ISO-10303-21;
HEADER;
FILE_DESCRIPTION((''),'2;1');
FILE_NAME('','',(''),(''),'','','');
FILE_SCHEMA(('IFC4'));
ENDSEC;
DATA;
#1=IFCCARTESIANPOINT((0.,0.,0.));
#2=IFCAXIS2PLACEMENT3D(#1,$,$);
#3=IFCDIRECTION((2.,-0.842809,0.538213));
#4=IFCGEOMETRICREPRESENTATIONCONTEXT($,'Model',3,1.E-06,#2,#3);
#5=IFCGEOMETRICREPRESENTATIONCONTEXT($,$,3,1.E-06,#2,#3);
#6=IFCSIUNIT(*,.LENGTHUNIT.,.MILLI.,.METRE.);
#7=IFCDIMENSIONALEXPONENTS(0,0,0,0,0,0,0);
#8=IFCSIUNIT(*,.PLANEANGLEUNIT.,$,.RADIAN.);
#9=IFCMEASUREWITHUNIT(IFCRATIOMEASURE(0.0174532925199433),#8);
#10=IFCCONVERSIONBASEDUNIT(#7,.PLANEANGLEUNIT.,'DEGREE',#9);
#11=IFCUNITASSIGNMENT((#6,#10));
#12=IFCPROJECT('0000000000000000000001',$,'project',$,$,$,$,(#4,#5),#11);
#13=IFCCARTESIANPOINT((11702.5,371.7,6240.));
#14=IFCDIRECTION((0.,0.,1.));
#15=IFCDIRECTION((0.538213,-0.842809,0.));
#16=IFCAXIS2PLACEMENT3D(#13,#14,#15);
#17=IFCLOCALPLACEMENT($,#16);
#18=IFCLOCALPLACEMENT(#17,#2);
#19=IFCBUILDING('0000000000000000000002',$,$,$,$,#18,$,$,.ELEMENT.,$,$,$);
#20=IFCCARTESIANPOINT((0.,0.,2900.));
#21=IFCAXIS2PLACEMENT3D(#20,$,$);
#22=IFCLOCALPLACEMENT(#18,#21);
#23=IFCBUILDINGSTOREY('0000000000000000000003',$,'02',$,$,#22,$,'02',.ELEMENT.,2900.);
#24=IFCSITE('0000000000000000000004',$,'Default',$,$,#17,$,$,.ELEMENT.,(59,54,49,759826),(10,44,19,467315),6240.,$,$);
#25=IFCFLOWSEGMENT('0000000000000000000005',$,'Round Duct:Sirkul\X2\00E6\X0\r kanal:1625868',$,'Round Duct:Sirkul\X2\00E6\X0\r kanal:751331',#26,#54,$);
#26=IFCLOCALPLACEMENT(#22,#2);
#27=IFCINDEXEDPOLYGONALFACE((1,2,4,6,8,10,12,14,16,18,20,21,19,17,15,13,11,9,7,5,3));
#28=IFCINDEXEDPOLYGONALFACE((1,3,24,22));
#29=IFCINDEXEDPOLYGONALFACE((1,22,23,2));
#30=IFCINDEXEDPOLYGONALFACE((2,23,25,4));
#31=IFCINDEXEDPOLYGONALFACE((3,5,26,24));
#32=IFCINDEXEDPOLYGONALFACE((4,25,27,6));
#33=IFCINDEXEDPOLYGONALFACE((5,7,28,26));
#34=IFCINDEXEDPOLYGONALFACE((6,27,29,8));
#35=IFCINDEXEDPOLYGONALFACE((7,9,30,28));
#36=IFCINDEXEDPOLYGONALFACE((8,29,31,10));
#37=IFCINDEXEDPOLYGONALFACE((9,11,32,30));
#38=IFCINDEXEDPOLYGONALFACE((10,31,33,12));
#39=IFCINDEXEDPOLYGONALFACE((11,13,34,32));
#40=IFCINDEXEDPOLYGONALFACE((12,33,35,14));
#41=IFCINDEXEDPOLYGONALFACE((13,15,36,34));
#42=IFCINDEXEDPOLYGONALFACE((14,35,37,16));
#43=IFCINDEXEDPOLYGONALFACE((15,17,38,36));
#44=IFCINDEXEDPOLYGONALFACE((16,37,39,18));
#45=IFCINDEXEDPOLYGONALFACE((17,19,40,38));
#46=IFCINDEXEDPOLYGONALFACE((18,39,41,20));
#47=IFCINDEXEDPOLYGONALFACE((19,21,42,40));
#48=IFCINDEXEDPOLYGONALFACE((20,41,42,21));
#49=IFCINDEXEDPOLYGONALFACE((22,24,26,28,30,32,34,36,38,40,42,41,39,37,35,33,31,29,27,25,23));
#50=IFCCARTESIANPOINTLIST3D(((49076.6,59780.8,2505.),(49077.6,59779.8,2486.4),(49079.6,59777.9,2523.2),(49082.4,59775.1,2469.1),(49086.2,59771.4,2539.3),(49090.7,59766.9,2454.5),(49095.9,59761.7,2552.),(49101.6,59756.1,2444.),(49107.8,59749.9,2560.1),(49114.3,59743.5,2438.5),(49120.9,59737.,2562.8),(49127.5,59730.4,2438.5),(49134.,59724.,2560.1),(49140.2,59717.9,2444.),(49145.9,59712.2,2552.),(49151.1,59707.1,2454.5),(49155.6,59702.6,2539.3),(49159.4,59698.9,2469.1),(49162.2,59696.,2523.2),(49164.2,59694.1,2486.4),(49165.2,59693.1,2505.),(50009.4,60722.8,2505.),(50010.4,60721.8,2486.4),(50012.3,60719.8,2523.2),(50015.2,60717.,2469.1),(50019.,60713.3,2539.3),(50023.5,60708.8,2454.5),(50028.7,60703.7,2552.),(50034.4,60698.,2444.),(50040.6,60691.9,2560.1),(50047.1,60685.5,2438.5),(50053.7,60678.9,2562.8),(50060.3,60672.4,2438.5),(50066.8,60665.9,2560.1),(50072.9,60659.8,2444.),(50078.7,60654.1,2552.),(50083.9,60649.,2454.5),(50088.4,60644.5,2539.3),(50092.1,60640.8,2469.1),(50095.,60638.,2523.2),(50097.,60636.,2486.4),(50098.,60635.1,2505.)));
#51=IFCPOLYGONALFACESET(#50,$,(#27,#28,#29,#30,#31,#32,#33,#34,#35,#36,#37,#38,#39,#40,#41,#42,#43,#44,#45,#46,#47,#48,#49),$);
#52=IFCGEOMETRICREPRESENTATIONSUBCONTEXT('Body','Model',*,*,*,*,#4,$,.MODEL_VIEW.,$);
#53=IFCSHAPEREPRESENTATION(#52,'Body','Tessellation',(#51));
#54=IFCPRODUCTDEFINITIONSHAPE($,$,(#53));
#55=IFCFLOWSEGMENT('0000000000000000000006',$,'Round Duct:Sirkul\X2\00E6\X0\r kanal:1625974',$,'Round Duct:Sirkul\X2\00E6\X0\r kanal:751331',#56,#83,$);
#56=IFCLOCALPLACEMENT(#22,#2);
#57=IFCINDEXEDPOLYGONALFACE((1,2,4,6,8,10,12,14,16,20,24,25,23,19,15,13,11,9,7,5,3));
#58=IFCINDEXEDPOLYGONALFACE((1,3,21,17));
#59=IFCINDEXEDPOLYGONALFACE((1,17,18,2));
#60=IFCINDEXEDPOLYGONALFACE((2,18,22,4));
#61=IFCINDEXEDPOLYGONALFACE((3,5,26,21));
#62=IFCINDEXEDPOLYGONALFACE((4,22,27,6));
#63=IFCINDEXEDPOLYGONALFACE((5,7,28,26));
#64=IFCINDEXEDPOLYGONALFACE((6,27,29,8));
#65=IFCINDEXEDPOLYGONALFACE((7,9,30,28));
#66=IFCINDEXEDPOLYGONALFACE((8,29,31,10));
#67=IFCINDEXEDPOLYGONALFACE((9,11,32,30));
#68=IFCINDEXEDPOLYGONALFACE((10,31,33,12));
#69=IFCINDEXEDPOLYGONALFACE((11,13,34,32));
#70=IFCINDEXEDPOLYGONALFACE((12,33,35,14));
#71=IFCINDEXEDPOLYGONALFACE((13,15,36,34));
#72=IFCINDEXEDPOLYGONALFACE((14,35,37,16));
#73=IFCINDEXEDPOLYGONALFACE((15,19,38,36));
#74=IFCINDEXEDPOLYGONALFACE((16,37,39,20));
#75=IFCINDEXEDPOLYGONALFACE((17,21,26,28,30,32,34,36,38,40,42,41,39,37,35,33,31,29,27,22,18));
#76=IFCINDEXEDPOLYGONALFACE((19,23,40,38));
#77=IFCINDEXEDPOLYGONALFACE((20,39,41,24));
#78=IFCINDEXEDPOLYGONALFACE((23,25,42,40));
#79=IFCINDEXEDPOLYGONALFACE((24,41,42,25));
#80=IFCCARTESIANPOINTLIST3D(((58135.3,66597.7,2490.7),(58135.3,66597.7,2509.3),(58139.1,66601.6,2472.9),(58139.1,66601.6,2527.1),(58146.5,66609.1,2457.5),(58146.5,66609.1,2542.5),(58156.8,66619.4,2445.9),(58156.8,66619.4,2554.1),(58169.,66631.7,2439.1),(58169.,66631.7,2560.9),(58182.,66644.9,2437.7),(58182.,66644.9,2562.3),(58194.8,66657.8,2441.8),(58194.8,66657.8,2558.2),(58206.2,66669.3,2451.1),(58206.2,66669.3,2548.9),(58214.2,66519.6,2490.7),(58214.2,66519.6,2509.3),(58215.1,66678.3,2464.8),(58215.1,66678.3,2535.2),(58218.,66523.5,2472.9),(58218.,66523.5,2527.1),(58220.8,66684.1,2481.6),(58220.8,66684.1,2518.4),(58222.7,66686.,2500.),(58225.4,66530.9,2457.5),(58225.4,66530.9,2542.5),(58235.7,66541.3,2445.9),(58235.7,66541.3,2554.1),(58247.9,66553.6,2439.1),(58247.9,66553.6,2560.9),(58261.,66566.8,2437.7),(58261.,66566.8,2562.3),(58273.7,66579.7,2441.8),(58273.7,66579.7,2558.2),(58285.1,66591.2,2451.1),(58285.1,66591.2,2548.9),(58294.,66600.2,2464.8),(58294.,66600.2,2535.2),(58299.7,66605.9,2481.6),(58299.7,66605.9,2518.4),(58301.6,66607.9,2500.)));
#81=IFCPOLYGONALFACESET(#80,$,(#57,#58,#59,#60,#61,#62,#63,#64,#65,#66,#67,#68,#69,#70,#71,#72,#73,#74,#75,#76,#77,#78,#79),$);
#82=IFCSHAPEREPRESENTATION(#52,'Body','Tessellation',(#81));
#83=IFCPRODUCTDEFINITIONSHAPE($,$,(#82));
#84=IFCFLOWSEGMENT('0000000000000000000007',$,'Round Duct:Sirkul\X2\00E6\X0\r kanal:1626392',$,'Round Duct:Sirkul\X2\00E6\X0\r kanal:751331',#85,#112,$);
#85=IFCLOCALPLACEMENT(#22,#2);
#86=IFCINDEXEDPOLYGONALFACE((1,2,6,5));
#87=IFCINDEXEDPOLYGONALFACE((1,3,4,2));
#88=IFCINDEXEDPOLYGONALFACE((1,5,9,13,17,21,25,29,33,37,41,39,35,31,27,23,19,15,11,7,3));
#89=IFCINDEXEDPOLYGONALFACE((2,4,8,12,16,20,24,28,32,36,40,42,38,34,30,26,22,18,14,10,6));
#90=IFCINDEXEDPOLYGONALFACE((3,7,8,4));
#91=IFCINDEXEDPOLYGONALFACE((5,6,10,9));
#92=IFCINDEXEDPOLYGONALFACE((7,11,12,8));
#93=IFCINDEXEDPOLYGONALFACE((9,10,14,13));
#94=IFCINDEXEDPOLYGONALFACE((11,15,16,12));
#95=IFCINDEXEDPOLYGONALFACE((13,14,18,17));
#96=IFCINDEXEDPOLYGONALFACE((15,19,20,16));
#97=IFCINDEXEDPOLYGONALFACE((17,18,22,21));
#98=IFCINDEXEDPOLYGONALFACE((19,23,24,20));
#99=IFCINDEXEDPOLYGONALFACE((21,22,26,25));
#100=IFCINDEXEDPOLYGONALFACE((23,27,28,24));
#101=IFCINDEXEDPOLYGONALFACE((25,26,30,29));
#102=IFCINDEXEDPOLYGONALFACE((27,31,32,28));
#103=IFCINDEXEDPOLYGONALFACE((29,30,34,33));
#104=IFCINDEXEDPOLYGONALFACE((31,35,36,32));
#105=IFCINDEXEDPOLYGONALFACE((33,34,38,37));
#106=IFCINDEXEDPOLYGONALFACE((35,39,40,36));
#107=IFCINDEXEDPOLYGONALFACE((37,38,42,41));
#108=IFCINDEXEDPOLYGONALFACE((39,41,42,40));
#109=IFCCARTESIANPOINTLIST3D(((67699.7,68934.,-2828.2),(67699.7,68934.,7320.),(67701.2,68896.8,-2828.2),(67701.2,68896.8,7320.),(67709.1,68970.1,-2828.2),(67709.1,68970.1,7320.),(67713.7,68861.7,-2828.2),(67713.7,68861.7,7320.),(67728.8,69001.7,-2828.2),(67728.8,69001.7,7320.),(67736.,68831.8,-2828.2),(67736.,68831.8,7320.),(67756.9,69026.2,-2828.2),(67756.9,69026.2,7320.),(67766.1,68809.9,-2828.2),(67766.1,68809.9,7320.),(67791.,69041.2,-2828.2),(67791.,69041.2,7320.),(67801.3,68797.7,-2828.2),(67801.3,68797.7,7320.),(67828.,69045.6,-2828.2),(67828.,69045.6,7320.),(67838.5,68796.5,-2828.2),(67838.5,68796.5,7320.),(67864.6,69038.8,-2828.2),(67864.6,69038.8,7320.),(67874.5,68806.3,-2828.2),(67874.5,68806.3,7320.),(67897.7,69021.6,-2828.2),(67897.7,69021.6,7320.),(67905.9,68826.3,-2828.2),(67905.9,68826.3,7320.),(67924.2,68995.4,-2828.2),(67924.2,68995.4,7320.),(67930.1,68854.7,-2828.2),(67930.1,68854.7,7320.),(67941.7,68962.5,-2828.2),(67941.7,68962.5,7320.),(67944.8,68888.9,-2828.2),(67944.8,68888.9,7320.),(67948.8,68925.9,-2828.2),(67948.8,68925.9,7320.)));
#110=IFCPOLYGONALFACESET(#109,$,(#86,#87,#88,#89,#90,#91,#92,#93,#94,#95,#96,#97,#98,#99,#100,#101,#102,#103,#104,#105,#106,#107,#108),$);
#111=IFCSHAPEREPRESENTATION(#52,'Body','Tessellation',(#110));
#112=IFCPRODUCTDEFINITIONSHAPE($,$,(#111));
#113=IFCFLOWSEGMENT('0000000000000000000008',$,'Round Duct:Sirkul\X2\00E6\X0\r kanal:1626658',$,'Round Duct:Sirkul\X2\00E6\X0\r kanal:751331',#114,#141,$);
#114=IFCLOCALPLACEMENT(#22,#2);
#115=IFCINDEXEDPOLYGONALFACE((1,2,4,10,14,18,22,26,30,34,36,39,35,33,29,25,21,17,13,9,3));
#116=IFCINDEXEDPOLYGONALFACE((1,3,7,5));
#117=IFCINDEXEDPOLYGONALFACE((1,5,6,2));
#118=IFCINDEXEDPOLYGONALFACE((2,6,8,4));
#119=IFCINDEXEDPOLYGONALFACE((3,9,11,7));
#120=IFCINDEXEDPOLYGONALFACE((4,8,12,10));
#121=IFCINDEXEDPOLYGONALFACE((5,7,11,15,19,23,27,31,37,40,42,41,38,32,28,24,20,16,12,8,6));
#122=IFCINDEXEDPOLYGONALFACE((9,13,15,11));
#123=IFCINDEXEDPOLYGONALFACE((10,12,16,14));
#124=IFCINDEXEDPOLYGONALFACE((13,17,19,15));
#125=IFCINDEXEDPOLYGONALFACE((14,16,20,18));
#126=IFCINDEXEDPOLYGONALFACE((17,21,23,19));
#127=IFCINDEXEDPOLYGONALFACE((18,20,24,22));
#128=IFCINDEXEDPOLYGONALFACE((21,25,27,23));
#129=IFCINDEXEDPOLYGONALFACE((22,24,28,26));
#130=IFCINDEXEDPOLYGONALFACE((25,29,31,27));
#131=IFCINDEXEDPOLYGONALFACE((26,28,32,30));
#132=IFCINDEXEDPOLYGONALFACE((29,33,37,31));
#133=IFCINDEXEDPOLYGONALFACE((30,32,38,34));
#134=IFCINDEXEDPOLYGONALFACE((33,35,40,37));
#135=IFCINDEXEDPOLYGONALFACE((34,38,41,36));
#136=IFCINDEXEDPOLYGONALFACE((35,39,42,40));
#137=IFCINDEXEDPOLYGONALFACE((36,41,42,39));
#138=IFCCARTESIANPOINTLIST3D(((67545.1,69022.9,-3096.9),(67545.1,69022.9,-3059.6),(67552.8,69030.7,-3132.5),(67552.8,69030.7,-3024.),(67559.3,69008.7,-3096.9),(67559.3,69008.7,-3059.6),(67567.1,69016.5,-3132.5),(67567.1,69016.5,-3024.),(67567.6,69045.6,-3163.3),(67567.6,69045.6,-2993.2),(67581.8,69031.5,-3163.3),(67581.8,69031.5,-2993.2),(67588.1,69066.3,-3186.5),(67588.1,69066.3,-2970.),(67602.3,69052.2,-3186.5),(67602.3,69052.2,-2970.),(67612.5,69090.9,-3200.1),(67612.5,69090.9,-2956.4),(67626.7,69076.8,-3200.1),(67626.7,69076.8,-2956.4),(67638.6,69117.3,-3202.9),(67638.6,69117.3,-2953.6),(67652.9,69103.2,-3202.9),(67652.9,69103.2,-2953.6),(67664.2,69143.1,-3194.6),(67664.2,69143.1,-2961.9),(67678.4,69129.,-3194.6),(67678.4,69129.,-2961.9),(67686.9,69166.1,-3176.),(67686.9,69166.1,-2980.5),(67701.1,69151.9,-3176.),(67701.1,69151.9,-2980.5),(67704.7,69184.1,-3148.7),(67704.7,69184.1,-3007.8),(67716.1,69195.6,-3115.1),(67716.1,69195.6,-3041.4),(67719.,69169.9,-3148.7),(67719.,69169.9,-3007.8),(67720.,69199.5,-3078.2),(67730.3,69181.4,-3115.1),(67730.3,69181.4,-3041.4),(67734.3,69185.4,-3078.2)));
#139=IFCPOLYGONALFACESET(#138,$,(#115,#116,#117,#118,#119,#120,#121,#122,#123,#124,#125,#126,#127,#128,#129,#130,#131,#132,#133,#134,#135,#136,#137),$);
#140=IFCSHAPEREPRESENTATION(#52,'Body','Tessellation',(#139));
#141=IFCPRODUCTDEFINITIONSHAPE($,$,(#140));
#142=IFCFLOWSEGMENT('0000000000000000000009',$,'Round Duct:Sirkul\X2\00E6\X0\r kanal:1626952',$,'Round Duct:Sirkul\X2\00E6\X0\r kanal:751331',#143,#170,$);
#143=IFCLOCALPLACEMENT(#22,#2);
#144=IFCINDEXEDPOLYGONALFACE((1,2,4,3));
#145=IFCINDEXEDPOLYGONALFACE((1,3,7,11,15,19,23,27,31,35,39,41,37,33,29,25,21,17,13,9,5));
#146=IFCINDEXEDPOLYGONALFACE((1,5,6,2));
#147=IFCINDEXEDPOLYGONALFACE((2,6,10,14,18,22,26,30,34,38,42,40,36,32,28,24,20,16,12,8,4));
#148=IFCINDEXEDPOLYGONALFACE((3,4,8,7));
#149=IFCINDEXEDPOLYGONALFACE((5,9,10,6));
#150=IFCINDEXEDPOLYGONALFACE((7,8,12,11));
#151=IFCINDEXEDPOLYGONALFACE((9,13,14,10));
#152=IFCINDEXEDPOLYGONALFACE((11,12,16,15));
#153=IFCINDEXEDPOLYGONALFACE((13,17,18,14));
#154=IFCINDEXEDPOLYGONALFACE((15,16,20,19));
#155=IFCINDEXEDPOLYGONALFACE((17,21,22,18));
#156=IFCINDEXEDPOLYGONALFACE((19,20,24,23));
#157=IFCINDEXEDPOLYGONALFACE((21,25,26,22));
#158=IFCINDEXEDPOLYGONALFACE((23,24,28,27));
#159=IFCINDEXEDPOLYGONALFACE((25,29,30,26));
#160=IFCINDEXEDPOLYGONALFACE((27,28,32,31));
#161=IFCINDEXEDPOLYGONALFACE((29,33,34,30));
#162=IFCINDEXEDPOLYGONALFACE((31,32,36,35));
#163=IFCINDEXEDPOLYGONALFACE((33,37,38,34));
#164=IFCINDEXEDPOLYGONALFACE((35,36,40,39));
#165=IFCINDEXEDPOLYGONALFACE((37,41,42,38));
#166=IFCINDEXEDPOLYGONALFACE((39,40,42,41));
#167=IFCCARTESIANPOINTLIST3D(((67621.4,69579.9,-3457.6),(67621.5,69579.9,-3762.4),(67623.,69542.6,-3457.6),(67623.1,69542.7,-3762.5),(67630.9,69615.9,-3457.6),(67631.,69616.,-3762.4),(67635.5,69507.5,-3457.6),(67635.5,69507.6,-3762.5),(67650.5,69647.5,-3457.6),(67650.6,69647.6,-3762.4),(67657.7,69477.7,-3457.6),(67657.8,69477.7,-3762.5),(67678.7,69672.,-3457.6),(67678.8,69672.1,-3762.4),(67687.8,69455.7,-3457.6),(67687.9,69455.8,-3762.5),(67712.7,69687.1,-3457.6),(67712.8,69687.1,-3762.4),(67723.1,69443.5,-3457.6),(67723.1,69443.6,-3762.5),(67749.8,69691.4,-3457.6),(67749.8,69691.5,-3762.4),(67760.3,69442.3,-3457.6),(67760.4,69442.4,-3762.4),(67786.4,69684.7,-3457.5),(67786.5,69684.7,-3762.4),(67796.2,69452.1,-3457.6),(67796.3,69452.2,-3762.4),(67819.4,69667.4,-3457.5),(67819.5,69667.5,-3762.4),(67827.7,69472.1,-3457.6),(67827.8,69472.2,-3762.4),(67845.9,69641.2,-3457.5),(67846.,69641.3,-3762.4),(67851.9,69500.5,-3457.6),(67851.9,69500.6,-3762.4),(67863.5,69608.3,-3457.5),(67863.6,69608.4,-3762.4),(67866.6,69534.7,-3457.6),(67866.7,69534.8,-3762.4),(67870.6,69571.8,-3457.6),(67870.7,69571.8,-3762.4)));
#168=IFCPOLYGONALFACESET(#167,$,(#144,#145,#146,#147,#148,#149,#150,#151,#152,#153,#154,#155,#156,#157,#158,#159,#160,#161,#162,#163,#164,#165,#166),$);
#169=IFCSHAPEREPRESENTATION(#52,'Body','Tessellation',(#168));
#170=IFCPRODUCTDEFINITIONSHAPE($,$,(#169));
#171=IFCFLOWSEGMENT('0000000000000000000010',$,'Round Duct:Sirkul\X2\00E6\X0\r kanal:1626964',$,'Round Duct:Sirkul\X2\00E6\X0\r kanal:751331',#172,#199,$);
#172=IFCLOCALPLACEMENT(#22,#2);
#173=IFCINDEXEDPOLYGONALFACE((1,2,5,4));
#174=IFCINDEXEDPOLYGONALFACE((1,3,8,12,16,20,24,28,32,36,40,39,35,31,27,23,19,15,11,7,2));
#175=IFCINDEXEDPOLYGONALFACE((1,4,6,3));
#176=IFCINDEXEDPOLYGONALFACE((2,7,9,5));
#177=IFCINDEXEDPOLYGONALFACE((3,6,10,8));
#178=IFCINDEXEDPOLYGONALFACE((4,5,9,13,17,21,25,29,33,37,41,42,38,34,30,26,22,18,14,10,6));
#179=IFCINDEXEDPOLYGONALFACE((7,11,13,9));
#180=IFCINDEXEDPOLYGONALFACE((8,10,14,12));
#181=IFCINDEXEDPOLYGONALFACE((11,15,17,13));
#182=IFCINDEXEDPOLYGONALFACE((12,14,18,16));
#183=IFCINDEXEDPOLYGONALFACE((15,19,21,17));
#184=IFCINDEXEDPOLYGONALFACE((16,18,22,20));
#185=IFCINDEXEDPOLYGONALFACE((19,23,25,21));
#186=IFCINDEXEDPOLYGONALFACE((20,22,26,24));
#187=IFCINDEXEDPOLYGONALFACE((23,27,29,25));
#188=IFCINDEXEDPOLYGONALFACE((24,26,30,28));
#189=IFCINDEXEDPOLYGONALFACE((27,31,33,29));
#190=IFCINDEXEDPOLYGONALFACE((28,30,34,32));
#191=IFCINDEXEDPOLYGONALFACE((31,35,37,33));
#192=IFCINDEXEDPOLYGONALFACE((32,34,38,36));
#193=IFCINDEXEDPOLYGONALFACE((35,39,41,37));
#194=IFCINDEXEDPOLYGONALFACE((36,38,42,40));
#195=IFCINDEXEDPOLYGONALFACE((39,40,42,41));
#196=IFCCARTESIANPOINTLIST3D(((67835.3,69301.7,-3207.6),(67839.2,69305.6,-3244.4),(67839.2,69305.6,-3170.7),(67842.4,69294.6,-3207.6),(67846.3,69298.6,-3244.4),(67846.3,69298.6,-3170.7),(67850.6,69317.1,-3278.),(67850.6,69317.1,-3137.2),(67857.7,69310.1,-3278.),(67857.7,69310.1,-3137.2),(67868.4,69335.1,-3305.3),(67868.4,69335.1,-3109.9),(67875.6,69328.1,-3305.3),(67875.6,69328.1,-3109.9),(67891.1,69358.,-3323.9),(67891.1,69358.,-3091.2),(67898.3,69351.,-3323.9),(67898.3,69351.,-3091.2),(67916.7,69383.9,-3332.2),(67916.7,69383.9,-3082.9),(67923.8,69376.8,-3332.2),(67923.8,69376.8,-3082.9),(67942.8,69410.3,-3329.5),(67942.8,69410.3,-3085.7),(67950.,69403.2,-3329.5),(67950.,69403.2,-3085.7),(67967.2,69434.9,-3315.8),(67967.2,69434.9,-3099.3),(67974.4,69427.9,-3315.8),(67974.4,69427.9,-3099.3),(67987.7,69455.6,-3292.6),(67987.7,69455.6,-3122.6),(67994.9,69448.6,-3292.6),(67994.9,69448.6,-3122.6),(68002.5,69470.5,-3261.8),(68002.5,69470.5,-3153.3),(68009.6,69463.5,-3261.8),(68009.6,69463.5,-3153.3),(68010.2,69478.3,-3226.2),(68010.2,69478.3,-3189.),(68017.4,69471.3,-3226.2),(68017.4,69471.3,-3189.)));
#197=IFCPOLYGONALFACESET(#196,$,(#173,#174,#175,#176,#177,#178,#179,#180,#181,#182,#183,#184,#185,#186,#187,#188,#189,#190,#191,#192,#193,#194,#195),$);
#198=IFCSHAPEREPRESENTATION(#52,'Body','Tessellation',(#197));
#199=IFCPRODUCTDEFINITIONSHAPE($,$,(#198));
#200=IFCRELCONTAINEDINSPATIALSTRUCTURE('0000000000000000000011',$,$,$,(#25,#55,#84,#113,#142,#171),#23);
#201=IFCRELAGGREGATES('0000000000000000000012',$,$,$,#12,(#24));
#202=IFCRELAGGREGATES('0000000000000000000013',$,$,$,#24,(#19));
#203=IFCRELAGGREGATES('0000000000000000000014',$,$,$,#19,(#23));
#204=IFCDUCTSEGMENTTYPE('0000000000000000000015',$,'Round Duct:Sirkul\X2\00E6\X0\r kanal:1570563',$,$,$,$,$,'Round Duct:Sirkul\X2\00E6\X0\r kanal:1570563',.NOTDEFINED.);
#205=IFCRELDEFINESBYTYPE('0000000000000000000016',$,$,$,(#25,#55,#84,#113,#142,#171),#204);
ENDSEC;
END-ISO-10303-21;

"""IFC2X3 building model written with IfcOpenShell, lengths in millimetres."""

from ifc_helpers import new_model, entity, si_unit, converted_unit, direction, frame, frame_2d, origin, origin_2d_with_axis, place, context, subcontext, project, spatial, circle, extrude, type_object, element, save


model = new_model("IFC2X3")

# Units and contexts
model_context = context("Model", 3, precision=1e-06, world=origin(), true_north=direction((2.0, -0.842809, 0.538213)))
context_of_model = context(None, 3, precision=1e-06, world=origin(), true_north=direction((2.0, -0.842809, 0.538213)))
body_context = subcontext(model_context, "Body", "Model", "MODEL_VIEW")
ifc_project = project(units=[si_unit("LENGTHUNIT", "METRE", prefix="MILLI"), converted_unit("PLANEANGLEUNIT", "DEGREE", entity("IfcRatioMeasure", 0.0174532925199433), si_unit("PLANEANGLEUNIT", "RADIAN"), dimensions=[0, 0, 0, 0, 0, 0, 0])], contexts=[model_context, context_of_model])

# Site, building, storey
site_placement = place(None, frame((11702.5, 371.7, 6240.0), z_axis=(0.0, 0.0, 1.0), x_axis=(0.538213, -0.842809, 0.0)))
site = spatial("IfcSite", under=ifc_project, at=site_placement, Name="Default", CompositionType="ELEMENT", RefLatitude=(59, 54, 49, 759826), RefLongitude=(10, 44, 19, 467315), RefElevation=6240.0)
building_placement = place(site_placement, origin())
building = spatial("IfcBuilding", under=site, at=building_placement, CompositionType="ELEMENT")
storey_placement = place(building_placement, frame((0.0, 0.0, 2900.0)))
storey = spatial("IfcBuildingStorey", under=building, at=storey_placement, Name="02", LongName="02", CompositionType="ELEMENT", Elevation=2900.0)

# Flow segments
duct_segment_type = type_object("IfcDuctSegmentType", Name="Round Duct:Sirkulær kanal:1570563", ElementType="Round Duct:Sirkulær kanal:1570563", PredefinedType="NOTDEFINED")
flow_segment_1_placement = place(storey_placement, origin())
element("IfcFlowSegment", 1, at=flow_segment_1_placement, inside=storey, type_object=duct_segment_type, Name="Round Duct:Sirkulær kanal:1625868", ObjectType="Round Duct:Sirkulær kanal:751331", context=body_context, shape_type="SweptSolid", body=[
    extrude(circle(Radius=62.5, at=frame_2d((0.0, 0.0), x_axis=(1.0, 0.0))), frame((49120.9, 59737.0, 2500.3), z_axis=(0.703641, 0.710556, 0.0), x_axis=(0.0, 0.0, 1.0)), (0.0, 0.0, 1.0), 1325.6),
])
flow_segment_2_placement = place(storey_placement, origin())
element("IfcFlowSegment", 2, at=flow_segment_2_placement, inside=storey, type_object=duct_segment_type, Name="Round Duct:Sirkulær kanal:1625974", ObjectType="Round Duct:Sirkulær kanal:751331", context=body_context, shape_type="SweptSolid", body=[
    extrude(circle(Radius=62.5, at=origin_2d_with_axis()), frame((58257.7, 66563.5, 2500.0), z_axis=(-0.710554, 0.703643, 0.0), x_axis=(0.703643, 0.710554, 0.0)), (0.0, 0.0, 1.0), 111.1),
])
flow_segment_3_placement = place(storey_placement, origin())
element("IfcFlowSegment", 3, at=flow_segment_3_placement, inside=storey, type_object=duct_segment_type, Name="Round Duct:Sirkulær kanal:1626392", ObjectType="Round Duct:Sirkulær kanal:751331", context=body_context, shape_type="SweptSolid", body=[
    extrude(circle(Radius=125.0, at=origin_2d_with_axis()), frame((67823.9, 68920.7, -2828.2), z_axis=(0.0, 0.0, 1.0), x_axis=(-0.703643, -0.710554, 0.0)), (0.0, 0.0, 1.0), 10148.2),
])
flow_segment_4_placement = place(storey_placement, origin())
element("IfcFlowSegment", 4, at=flow_segment_4_placement, inside=storey, type_object=duct_segment_type, Name="Round Duct:Sirkulær kanal:1626658", ObjectType="Round Duct:Sirkulær kanal:751331", context=body_context, shape_type="SweptSolid", body=[
    extrude(circle(Radius=125.0, at=frame_2d((0.0, 0.0), x_axis=(1.0, 0.0))), frame((67646.3, 69096.6, -3078.2), z_axis=(-0.710554, 0.703643, 0.0), x_axis=(0.703643, 0.710554, 0.0)), (0.0, 0.0, 1.0), 20.1),
])
flow_segment_5_placement = place(storey_placement, origin())
element("IfcFlowSegment", 5, at=flow_segment_5_placement, inside=storey, type_object=duct_segment_type, Name="Round Duct:Sirkulær kanal:1626952", ObjectType="Round Duct:Sirkulær kanal:751331", context=body_context, shape_type="SweptSolid", body=[
    extrude(circle(Radius=125.0, at=frame_2d((0.0, 0.0), x_axis=(1.0, 0.0))), frame((67745.8, 69566.6, -3762.4), z_axis=(-0.00027, -0.000264, 1.0), x_axis=(-0.703643, -0.710554, -0.000378)), (0.0, 0.0, 1.0), 304.8),
])
flow_segment_6_placement = place(storey_placement, origin())
element("IfcFlowSegment", 6, at=flow_segment_6_placement, inside=storey, type_object=duct_segment_type, Name="Round Duct:Sirkulær kanal:1626964", ObjectType="Round Duct:Sirkulær kanal:751331", context=body_context, shape_type="SweptSolid", body=[
    extrude(circle(Radius=125.0, at=frame_2d((0.0, 0.0), x_axis=(1.0, 0.0))), frame((67923.3, 69390.5, -3207.6), z_axis=(0.710554, -0.703643, 0.0), x_axis=(-0.703643, -0.710554, 0.0)), (0.0, 0.0, 1.0), 10.0),
])

save(model, "model.ifc")
